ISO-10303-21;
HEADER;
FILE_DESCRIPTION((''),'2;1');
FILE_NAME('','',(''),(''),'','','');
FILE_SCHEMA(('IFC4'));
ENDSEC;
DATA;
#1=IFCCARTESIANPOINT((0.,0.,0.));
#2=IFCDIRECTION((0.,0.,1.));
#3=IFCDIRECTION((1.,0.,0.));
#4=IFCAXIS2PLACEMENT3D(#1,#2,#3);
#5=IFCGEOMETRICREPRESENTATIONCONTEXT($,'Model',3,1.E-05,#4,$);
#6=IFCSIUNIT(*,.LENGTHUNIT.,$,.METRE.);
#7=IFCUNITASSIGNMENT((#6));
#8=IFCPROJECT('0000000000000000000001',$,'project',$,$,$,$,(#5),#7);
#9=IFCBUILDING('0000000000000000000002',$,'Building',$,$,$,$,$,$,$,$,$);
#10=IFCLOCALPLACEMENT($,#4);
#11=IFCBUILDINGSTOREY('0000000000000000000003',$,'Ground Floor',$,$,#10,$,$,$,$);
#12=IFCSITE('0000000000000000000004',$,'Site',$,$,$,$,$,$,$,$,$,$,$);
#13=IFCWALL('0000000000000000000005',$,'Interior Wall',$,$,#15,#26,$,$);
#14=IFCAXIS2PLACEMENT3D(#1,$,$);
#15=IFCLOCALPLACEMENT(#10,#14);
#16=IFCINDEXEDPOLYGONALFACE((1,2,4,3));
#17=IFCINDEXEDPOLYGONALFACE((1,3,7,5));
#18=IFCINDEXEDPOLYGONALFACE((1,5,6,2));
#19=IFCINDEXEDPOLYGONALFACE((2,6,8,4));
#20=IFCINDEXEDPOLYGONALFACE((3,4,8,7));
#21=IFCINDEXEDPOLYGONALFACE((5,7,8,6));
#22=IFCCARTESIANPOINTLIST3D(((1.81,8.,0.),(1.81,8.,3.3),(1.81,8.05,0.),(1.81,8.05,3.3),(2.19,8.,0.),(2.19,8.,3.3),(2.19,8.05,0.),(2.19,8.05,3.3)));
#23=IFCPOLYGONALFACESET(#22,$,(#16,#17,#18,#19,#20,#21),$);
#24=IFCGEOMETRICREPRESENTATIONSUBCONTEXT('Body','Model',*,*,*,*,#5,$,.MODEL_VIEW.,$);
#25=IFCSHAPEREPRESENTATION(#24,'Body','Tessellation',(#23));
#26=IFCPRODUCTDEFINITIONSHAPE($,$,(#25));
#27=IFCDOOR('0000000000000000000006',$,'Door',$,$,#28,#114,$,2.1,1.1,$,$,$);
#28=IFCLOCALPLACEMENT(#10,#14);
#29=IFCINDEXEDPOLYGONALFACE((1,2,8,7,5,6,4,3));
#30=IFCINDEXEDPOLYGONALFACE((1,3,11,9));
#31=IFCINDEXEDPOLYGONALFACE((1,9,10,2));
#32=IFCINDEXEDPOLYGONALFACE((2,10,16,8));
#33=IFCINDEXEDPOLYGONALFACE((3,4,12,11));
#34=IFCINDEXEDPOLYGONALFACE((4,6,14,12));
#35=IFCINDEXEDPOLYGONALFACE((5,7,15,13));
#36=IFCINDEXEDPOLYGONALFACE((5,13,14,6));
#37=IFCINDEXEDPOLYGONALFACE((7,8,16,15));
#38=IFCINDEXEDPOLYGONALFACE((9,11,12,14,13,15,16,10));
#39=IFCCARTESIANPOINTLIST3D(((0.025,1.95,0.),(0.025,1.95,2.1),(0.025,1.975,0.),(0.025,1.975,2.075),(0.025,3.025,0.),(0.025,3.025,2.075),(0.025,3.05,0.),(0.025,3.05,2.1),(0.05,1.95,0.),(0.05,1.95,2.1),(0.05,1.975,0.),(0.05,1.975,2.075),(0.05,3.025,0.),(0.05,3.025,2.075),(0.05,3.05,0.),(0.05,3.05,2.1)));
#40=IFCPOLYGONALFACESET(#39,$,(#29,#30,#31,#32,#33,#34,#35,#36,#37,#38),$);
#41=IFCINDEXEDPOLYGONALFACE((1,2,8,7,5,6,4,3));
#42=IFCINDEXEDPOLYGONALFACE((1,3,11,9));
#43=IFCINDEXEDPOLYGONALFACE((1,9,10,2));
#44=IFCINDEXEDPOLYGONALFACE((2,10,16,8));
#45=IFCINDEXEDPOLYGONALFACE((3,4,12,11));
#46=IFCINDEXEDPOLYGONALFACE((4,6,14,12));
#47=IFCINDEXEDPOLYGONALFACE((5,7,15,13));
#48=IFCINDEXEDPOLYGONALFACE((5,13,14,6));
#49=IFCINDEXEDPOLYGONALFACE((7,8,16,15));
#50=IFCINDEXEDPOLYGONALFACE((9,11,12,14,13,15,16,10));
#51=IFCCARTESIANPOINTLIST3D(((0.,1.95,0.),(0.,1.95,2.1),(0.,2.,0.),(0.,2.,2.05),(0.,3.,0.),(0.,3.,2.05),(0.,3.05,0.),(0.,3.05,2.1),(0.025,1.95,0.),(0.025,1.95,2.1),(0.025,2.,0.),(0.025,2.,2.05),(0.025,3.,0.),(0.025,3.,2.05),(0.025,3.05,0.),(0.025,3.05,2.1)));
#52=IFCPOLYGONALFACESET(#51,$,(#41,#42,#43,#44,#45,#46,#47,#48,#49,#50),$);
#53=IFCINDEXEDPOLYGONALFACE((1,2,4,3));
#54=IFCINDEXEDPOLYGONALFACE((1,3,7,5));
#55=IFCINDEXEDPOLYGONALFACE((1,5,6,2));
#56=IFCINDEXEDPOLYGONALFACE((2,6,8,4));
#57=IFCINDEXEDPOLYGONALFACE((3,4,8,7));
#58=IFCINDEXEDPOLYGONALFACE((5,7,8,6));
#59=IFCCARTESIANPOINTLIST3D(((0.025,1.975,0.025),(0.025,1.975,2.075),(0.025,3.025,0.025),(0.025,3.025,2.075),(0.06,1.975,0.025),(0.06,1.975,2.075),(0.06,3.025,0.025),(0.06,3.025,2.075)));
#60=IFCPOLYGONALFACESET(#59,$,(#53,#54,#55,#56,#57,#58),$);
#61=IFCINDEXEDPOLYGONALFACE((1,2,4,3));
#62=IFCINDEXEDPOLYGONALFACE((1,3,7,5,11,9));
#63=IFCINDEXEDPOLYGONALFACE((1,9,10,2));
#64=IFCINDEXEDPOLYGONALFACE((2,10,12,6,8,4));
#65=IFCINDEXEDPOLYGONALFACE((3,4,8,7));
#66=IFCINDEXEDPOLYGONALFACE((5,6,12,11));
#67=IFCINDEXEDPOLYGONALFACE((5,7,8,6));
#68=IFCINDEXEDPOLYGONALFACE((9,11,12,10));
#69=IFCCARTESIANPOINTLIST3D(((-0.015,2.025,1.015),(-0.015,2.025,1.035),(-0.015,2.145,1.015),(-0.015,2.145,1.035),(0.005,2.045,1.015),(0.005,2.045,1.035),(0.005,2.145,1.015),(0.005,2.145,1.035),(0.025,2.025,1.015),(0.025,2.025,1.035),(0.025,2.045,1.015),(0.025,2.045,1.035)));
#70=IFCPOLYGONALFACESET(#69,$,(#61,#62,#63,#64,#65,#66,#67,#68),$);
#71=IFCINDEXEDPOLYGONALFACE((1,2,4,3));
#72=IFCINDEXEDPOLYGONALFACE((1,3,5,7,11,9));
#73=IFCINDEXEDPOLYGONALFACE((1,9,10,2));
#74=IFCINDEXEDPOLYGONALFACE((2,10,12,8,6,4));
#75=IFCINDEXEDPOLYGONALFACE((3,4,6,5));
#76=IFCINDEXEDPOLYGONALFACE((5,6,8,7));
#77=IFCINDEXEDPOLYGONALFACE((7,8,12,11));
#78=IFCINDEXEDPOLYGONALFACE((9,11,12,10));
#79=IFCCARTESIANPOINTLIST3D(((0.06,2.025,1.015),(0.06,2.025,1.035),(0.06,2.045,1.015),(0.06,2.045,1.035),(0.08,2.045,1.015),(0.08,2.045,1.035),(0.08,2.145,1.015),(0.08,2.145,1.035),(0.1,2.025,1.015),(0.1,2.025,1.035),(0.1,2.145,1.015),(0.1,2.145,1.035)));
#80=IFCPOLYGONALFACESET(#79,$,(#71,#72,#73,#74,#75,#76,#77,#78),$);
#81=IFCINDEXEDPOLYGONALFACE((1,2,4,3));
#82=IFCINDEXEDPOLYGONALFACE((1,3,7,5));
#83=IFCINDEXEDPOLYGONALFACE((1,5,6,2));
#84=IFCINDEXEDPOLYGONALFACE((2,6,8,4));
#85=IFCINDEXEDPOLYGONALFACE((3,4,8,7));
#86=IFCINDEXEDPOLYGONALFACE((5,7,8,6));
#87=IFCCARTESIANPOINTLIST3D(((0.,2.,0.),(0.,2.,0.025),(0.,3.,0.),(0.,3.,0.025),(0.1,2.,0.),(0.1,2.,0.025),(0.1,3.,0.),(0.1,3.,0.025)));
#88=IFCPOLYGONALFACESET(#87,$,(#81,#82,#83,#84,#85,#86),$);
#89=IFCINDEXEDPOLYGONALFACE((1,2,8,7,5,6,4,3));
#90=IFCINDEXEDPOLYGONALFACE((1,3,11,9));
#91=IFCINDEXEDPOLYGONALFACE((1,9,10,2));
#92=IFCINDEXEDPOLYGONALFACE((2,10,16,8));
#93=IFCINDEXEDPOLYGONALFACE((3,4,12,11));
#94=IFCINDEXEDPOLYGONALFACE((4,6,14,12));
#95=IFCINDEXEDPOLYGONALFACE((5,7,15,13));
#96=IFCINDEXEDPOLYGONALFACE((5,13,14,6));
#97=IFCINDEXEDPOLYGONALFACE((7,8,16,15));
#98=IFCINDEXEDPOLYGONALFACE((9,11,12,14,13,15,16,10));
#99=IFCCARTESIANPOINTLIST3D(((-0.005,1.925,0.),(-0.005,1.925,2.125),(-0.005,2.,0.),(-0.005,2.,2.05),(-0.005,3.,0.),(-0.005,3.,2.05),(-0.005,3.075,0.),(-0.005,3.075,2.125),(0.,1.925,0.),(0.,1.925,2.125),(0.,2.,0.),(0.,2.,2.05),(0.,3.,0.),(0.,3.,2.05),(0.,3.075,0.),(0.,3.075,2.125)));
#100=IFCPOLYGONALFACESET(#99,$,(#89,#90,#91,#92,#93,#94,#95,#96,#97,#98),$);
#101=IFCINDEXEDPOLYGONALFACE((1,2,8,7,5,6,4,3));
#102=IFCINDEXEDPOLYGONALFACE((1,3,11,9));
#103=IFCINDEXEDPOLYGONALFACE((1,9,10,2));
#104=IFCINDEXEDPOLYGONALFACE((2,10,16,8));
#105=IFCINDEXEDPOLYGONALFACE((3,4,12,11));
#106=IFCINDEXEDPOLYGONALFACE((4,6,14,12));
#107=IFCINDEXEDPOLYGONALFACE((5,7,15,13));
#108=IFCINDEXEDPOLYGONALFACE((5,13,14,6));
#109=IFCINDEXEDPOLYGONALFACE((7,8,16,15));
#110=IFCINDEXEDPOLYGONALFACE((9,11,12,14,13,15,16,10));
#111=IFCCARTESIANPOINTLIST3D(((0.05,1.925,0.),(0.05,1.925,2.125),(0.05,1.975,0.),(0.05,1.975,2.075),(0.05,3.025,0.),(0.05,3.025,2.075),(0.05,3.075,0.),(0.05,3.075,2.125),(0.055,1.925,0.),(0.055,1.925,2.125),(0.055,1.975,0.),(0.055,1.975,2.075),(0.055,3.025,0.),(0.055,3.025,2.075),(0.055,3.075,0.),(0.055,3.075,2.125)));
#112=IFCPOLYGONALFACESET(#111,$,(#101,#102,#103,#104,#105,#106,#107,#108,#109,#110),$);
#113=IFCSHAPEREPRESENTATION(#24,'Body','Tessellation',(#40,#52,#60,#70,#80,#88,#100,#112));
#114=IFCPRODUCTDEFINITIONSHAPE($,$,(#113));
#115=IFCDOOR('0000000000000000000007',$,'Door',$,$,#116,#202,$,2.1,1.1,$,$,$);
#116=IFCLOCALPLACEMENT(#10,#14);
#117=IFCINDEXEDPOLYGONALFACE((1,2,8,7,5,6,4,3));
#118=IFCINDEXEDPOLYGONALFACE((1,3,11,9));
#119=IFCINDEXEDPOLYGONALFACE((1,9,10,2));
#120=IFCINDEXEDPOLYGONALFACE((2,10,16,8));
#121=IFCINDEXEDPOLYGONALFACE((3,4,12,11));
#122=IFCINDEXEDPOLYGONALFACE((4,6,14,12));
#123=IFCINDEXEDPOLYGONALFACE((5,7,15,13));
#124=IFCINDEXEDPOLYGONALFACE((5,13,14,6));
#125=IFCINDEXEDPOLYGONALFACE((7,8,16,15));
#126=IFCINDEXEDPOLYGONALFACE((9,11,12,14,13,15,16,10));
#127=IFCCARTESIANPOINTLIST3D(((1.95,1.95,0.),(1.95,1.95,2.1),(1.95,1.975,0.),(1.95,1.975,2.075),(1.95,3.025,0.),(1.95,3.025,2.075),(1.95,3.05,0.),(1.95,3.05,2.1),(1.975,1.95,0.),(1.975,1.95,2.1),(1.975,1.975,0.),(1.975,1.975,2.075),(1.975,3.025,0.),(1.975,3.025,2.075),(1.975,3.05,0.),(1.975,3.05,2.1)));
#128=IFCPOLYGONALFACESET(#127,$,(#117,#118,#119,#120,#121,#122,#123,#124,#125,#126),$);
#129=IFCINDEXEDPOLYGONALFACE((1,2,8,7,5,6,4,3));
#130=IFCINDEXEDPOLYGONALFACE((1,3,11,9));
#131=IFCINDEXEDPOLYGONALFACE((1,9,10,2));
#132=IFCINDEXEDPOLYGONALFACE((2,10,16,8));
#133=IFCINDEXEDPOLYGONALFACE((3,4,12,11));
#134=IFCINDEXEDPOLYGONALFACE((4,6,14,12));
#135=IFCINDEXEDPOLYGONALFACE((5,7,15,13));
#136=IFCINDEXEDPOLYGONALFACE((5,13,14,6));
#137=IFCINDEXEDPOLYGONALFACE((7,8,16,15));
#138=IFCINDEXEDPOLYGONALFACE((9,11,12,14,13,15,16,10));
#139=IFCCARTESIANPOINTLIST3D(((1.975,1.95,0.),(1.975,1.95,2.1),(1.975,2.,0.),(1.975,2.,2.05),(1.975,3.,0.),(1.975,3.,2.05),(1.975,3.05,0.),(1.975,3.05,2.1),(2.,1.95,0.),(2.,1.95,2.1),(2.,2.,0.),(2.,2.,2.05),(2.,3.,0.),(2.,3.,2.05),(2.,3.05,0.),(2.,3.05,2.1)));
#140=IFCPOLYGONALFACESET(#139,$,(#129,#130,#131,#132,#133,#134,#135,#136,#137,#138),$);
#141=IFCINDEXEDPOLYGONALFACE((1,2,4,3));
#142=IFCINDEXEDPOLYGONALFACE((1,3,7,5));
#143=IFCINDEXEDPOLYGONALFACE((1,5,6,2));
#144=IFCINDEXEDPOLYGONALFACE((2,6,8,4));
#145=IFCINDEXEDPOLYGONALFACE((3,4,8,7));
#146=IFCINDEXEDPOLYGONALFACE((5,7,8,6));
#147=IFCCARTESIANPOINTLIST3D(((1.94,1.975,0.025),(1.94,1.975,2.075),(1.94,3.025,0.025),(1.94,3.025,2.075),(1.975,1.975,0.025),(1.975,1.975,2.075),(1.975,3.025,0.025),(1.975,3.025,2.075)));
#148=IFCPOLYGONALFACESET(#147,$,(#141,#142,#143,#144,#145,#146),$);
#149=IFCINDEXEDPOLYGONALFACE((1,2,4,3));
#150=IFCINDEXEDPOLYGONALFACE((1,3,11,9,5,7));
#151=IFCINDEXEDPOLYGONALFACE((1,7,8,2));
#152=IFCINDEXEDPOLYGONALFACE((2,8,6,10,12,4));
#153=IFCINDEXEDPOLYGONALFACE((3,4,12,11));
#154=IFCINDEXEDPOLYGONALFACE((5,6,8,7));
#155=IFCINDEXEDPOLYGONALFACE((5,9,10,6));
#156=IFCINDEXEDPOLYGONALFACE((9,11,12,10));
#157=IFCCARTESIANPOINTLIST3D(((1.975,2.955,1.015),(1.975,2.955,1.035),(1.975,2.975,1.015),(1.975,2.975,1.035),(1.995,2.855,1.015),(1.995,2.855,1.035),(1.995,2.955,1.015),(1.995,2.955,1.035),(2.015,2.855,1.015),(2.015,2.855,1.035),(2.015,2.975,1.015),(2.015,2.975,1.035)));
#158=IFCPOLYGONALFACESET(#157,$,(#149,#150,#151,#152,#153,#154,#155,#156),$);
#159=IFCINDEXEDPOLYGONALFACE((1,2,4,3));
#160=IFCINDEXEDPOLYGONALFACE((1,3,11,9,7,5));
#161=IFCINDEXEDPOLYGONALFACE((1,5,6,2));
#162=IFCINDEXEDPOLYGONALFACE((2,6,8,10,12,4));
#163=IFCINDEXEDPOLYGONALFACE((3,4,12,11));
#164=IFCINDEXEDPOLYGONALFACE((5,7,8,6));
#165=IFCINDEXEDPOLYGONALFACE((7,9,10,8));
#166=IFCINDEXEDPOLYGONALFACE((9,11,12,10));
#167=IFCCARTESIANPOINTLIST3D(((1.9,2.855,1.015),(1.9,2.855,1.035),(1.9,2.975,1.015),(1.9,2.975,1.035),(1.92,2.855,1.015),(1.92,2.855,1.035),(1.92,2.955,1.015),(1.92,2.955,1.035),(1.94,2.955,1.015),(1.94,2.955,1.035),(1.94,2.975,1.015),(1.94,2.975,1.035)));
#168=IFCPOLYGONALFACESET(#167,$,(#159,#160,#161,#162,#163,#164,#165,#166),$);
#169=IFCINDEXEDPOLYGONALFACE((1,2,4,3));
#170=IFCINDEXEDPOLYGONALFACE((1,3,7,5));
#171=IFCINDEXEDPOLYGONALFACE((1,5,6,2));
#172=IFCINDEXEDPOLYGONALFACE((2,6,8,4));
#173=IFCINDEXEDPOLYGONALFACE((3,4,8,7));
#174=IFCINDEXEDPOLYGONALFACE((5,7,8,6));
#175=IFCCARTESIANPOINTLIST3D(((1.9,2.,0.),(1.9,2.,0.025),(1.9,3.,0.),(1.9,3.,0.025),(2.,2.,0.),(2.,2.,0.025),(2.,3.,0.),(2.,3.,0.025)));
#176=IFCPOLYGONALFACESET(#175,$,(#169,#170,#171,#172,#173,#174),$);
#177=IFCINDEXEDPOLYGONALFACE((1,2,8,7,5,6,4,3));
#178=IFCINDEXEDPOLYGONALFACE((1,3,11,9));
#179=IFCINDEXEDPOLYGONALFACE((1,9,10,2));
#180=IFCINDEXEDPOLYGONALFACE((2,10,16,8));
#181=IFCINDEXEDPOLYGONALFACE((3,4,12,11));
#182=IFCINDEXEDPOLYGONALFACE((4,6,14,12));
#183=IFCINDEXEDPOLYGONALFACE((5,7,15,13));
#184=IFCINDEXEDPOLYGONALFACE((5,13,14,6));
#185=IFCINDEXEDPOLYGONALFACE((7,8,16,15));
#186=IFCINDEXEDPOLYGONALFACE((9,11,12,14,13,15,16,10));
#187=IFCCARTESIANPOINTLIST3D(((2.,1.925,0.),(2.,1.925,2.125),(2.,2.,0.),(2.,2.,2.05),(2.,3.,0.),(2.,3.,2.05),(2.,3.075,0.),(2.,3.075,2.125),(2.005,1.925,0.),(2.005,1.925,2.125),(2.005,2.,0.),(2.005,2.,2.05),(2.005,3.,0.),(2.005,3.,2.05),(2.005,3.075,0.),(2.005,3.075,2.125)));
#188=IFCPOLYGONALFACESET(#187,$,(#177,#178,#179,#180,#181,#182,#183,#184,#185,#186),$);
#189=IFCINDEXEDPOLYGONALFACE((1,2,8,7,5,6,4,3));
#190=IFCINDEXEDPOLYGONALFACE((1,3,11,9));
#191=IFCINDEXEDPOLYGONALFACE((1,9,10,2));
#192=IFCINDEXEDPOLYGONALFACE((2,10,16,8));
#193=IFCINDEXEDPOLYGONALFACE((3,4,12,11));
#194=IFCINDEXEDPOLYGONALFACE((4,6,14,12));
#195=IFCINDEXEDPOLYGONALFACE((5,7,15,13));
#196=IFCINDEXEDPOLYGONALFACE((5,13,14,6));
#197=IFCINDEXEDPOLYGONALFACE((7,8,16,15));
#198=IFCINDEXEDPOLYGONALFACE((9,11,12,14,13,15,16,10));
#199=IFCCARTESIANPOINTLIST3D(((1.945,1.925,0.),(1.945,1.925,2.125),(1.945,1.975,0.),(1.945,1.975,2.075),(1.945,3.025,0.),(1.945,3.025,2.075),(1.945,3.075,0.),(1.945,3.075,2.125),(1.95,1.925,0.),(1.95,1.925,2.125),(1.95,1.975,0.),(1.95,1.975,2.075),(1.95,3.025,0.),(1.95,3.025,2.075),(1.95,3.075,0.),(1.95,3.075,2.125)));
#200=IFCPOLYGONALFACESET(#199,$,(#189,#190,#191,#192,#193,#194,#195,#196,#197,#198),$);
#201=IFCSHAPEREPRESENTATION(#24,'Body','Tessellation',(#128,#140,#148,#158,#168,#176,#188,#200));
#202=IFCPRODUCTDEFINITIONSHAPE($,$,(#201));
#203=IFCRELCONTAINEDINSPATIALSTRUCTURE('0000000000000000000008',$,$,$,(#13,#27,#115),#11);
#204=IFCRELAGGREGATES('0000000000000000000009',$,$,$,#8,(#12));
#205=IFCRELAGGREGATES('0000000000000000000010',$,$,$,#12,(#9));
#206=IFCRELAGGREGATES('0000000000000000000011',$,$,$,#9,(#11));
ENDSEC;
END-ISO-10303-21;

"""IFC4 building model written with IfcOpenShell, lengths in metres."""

from ifc_helpers import new_model, si_unit, frame, origin_with_axes, place, context, subcontext, project, spatial, line, indexed_curve, outline, extrude, element, save


model = new_model("IFC4")

# Units and contexts
model_context = context("Model", 3, precision=1e-05, world=origin_with_axes())
body_context = subcontext(model_context, "Body", "Model", "MODEL_VIEW")
ifc_project = project(units=[si_unit("LENGTHUNIT", "METRE")], contexts=[model_context])

# Site, building, storey
site = spatial("IfcSite", under=ifc_project, Name="Site")
building = spatial("IfcBuilding", under=site, Name="Building")
storey_placement = place(None, origin_with_axes())
storey = spatial("IfcBuildingStorey", under=building, at=storey_placement, Name="Ground Floor")

# Wall
for number, where, z_axis, x_axis, name in (
    (1, (2.0, 8.05, 0.0), (0.0, 0.0, 1.0), (0.0, -1.0, 0.0), "Interior Wall"),
):
    element("IfcWall", number, at=place(storey_placement, frame(where, z_axis=z_axis, x_axis=x_axis)), inside=storey, Name=name, context=body_context, shape_type="SweptSolid", body=[
        extrude(outline(indexed_curve([(0.0, 0.0), (0.0, 0.38), (0.05, 0.38), (0.05, 0.0), (0.0, 0.0)], self_intersect=False)), frame((0.0, -0.19, 0.0), z_axis=(0.0, 0.0, 1.0), x_axis=(1.0, 0.0, 0.0)), (0.0, 0.0, 1.0), 3.3),
    ])

# Doors
door_1_placement = place(storey_placement, frame((0.0, 3.05, 0.0), z_axis=(0.0, 0.0, 1.0), x_axis=(0.0, -1.0, 0.0)))
element("IfcDoor", 2, at=door_1_placement, inside=storey, Name="Door", OverallHeight=2.1, OverallWidth=1.1, context=body_context, shape_type="SweptSolid", body=[
    extrude(outline(indexed_curve([(0.0, 0.0), (0.0, 2.1), (1.1, 2.1), (1.1, 0.0), (1.075, 0.0), (1.075, 2.075), (0.025, 2.075), (0.025, 0.0)], segments=[line(1, 2, 3, 4, 5, 6, 7, 8, 1)])), frame((0.0, 0.025, 0.0), z_axis=(0.0, -1.0, 0.0), x_axis=(1.0, 0.0, 0.0)), (0.0, 0.0, -1.0), 0.025),
    extrude(outline(indexed_curve([(0.0, 0.0), (0.0, 2.1), (1.1, 2.1), (1.1, 0.0), (1.05, 0.0), (1.05, 2.05), (0.05, 2.05), (0.05, 0.0)], segments=[line(1, 2, 3, 4, 5, 6, 7, 8, 1)])), frame((0.0, 0.0, 0.0), z_axis=(0.0, -1.0, 0.0), x_axis=(1.0, 0.0, 0.0)), (0.0, 0.0, -1.0), 0.025),
    extrude(outline(indexed_curve([(0.0, 0.0), (1.05, 0.0), (1.05, 0.035), (0.0, 0.035)], segments=[line(1, 2, 3, 4, 1)])), frame((0.025, 0.025, 0.025), z_axis=(0.0, 0.0, 1.0), x_axis=(1.0, 0.0, 0.0)), (0.0, 0.0, 1.0), 2.05),
    extrude(outline(indexed_curve([(0.0, 0.0), (0.0, -0.04), (-0.12, -0.04), (-0.12, -0.02), (-0.02, -0.02), (-0.02, 0.0)], segments=[line(1, 2, 3, 4, 5, 6, 1)])), frame((1.025, 0.025, 1.015), z_axis=(0.0, 0.0, 1.0), x_axis=(1.0, 0.0, 0.0)), (0.0, 0.0, 1.0), 0.02),
    extrude(outline(indexed_curve([(0.0, 0.0), (0.0, 0.04), (-0.12, 0.04), (-0.12, 0.02), (-0.02, 0.02), (-0.02, 0.0)], segments=[line(1, 2, 3, 4, 5, 6, 1)])), frame((1.025, 0.06, 1.015), z_axis=(0.0, 0.0, 1.0), x_axis=(1.0, 0.0, 0.0)), (0.0, 0.0, 1.0), 0.02),
    extrude(outline(indexed_curve([(0.0, 0.0), (1.0, 0.0), (1.0, 0.1), (0.0, 0.1)], segments=[line(1, 2, 3, 4, 1)])), frame((0.05, 0.0, 0.0), z_axis=(0.0, 0.0, 1.0), x_axis=(1.0, 0.0, 0.0)), (0.0, 0.0, 1.0), 0.025),
    extrude(outline(indexed_curve([(0.0, 0.0), (0.0, 2.125), (1.15, 2.125), (1.15, 0.0), (1.075, 0.0), (1.075, 2.05), (0.075, 2.05), (0.075, 0.0)], segments=[line(1, 2, 3, 4, 5, 6, 7, 8, 1)])), frame((-0.025, -0.005, 0.0), z_axis=(0.0, -1.0, 0.0), x_axis=(1.0, 0.0, 0.0)), (0.0, 0.0, -1.0), 0.005),
    extrude(outline(indexed_curve([(0.0, 0.0), (0.0, 2.125), (1.15, 2.125), (1.15, 0.0), (1.1, 0.0), (1.1, 2.075), (0.05, 2.075), (0.05, 0.0)], segments=[line(1, 2, 3, 4, 5, 6, 7, 8, 1)])), frame((-0.025, 0.05, 0.0), z_axis=(0.0, -1.0, 0.0), x_axis=(1.0, 0.0, 0.0)), (0.0, 0.0, -1.0), 0.005),
])
door_2_placement = place(storey_placement, frame((2.0, 1.95, 0.0), z_axis=(0.0, 0.0, 1.0), x_axis=(0.0, 1.0, 0.0)))
element("IfcDoor", 3, at=door_2_placement, inside=storey, Name="Door", OverallHeight=2.1, OverallWidth=1.1, context=body_context, shape_type="SweptSolid", body=[
    extrude(outline(indexed_curve([(0.0, 0.0), (0.0, 2.1), (1.1, 2.1), (1.1, 0.0), (1.075, 0.0), (1.075, 2.075), (0.025, 2.075), (0.025, 0.0)], segments=[line(1, 2, 3, 4, 5, 6, 7, 8, 1)])), frame((0.0, 0.025, 0.0), z_axis=(0.0, -1.0, 0.0), x_axis=(1.0, 0.0, 0.0)), (0.0, 0.0, -1.0), 0.025),
    extrude(outline(indexed_curve([(0.0, 0.0), (0.0, 2.1), (1.1, 2.1), (1.1, 0.0), (1.05, 0.0), (1.05, 2.05), (0.05, 2.05), (0.05, 0.0)], segments=[line(1, 2, 3, 4, 5, 6, 7, 8, 1)])), frame((0.0, 0.0, 0.0), z_axis=(0.0, -1.0, 0.0), x_axis=(1.0, 0.0, 0.0)), (0.0, 0.0, -1.0), 0.025),
    extrude(outline(indexed_curve([(0.0, 0.0), (1.05, 0.0), (1.05, 0.035), (0.0, 0.035)], segments=[line(1, 2, 3, 4, 1)])), frame((0.025, 0.025, 0.025), z_axis=(0.0, 0.0, 1.0), x_axis=(1.0, 0.0, 0.0)), (0.0, 0.0, 1.0), 2.05),
    extrude(outline(indexed_curve([(0.0, 0.0), (0.0, -0.04), (-0.12, -0.04), (-0.12, -0.02), (-0.02, -0.02), (-0.02, 0.0)], segments=[line(1, 2, 3, 4, 5, 6, 1)])), frame((1.025, 0.025, 1.015), z_axis=(0.0, 0.0, 1.0), x_axis=(1.0, 0.0, 0.0)), (0.0, 0.0, 1.0), 0.02),
    extrude(outline(indexed_curve([(0.0, 0.0), (0.0, 0.04), (-0.12, 0.04), (-0.12, 0.02), (-0.02, 0.02), (-0.02, 0.0)], segments=[line(1, 2, 3, 4, 5, 6, 1)])), frame((1.025, 0.06, 1.015), z_axis=(0.0, 0.0, 1.0), x_axis=(1.0, 0.0, 0.0)), (0.0, 0.0, 1.0), 0.02),
    extrude(outline(indexed_curve([(0.0, 0.0), (1.0, 0.0), (1.0, 0.1), (0.0, 0.1)], segments=[line(1, 2, 3, 4, 1)])), frame((0.05, 0.0, 0.0), z_axis=(0.0, 0.0, 1.0), x_axis=(1.0, 0.0, 0.0)), (0.0, 0.0, 1.0), 0.025),
    extrude(outline(indexed_curve([(0.0, 0.0), (0.0, 2.125), (1.15, 2.125), (1.15, 0.0), (1.075, 0.0), (1.075, 2.05), (0.075, 2.05), (0.075, 0.0)], segments=[line(1, 2, 3, 4, 5, 6, 7, 8, 1)])), frame((-0.025, -0.005, 0.0), z_axis=(0.0, -1.0, 0.0), x_axis=(1.0, 0.0, 0.0)), (0.0, 0.0, -1.0), 0.005),
    extrude(outline(indexed_curve([(0.0, 0.0), (0.0, 2.125), (1.15, 2.125), (1.15, 0.0), (1.1, 0.0), (1.1, 2.075), (0.05, 2.075), (0.05, 0.0)], segments=[line(1, 2, 3, 4, 5, 6, 7, 8, 1)])), frame((-0.025, 0.05, 0.0), z_axis=(0.0, -1.0, 0.0), x_axis=(1.0, 0.0, 0.0)), (0.0, 0.0, -1.0), 0.005),
])

save(model, "model.ifc")
